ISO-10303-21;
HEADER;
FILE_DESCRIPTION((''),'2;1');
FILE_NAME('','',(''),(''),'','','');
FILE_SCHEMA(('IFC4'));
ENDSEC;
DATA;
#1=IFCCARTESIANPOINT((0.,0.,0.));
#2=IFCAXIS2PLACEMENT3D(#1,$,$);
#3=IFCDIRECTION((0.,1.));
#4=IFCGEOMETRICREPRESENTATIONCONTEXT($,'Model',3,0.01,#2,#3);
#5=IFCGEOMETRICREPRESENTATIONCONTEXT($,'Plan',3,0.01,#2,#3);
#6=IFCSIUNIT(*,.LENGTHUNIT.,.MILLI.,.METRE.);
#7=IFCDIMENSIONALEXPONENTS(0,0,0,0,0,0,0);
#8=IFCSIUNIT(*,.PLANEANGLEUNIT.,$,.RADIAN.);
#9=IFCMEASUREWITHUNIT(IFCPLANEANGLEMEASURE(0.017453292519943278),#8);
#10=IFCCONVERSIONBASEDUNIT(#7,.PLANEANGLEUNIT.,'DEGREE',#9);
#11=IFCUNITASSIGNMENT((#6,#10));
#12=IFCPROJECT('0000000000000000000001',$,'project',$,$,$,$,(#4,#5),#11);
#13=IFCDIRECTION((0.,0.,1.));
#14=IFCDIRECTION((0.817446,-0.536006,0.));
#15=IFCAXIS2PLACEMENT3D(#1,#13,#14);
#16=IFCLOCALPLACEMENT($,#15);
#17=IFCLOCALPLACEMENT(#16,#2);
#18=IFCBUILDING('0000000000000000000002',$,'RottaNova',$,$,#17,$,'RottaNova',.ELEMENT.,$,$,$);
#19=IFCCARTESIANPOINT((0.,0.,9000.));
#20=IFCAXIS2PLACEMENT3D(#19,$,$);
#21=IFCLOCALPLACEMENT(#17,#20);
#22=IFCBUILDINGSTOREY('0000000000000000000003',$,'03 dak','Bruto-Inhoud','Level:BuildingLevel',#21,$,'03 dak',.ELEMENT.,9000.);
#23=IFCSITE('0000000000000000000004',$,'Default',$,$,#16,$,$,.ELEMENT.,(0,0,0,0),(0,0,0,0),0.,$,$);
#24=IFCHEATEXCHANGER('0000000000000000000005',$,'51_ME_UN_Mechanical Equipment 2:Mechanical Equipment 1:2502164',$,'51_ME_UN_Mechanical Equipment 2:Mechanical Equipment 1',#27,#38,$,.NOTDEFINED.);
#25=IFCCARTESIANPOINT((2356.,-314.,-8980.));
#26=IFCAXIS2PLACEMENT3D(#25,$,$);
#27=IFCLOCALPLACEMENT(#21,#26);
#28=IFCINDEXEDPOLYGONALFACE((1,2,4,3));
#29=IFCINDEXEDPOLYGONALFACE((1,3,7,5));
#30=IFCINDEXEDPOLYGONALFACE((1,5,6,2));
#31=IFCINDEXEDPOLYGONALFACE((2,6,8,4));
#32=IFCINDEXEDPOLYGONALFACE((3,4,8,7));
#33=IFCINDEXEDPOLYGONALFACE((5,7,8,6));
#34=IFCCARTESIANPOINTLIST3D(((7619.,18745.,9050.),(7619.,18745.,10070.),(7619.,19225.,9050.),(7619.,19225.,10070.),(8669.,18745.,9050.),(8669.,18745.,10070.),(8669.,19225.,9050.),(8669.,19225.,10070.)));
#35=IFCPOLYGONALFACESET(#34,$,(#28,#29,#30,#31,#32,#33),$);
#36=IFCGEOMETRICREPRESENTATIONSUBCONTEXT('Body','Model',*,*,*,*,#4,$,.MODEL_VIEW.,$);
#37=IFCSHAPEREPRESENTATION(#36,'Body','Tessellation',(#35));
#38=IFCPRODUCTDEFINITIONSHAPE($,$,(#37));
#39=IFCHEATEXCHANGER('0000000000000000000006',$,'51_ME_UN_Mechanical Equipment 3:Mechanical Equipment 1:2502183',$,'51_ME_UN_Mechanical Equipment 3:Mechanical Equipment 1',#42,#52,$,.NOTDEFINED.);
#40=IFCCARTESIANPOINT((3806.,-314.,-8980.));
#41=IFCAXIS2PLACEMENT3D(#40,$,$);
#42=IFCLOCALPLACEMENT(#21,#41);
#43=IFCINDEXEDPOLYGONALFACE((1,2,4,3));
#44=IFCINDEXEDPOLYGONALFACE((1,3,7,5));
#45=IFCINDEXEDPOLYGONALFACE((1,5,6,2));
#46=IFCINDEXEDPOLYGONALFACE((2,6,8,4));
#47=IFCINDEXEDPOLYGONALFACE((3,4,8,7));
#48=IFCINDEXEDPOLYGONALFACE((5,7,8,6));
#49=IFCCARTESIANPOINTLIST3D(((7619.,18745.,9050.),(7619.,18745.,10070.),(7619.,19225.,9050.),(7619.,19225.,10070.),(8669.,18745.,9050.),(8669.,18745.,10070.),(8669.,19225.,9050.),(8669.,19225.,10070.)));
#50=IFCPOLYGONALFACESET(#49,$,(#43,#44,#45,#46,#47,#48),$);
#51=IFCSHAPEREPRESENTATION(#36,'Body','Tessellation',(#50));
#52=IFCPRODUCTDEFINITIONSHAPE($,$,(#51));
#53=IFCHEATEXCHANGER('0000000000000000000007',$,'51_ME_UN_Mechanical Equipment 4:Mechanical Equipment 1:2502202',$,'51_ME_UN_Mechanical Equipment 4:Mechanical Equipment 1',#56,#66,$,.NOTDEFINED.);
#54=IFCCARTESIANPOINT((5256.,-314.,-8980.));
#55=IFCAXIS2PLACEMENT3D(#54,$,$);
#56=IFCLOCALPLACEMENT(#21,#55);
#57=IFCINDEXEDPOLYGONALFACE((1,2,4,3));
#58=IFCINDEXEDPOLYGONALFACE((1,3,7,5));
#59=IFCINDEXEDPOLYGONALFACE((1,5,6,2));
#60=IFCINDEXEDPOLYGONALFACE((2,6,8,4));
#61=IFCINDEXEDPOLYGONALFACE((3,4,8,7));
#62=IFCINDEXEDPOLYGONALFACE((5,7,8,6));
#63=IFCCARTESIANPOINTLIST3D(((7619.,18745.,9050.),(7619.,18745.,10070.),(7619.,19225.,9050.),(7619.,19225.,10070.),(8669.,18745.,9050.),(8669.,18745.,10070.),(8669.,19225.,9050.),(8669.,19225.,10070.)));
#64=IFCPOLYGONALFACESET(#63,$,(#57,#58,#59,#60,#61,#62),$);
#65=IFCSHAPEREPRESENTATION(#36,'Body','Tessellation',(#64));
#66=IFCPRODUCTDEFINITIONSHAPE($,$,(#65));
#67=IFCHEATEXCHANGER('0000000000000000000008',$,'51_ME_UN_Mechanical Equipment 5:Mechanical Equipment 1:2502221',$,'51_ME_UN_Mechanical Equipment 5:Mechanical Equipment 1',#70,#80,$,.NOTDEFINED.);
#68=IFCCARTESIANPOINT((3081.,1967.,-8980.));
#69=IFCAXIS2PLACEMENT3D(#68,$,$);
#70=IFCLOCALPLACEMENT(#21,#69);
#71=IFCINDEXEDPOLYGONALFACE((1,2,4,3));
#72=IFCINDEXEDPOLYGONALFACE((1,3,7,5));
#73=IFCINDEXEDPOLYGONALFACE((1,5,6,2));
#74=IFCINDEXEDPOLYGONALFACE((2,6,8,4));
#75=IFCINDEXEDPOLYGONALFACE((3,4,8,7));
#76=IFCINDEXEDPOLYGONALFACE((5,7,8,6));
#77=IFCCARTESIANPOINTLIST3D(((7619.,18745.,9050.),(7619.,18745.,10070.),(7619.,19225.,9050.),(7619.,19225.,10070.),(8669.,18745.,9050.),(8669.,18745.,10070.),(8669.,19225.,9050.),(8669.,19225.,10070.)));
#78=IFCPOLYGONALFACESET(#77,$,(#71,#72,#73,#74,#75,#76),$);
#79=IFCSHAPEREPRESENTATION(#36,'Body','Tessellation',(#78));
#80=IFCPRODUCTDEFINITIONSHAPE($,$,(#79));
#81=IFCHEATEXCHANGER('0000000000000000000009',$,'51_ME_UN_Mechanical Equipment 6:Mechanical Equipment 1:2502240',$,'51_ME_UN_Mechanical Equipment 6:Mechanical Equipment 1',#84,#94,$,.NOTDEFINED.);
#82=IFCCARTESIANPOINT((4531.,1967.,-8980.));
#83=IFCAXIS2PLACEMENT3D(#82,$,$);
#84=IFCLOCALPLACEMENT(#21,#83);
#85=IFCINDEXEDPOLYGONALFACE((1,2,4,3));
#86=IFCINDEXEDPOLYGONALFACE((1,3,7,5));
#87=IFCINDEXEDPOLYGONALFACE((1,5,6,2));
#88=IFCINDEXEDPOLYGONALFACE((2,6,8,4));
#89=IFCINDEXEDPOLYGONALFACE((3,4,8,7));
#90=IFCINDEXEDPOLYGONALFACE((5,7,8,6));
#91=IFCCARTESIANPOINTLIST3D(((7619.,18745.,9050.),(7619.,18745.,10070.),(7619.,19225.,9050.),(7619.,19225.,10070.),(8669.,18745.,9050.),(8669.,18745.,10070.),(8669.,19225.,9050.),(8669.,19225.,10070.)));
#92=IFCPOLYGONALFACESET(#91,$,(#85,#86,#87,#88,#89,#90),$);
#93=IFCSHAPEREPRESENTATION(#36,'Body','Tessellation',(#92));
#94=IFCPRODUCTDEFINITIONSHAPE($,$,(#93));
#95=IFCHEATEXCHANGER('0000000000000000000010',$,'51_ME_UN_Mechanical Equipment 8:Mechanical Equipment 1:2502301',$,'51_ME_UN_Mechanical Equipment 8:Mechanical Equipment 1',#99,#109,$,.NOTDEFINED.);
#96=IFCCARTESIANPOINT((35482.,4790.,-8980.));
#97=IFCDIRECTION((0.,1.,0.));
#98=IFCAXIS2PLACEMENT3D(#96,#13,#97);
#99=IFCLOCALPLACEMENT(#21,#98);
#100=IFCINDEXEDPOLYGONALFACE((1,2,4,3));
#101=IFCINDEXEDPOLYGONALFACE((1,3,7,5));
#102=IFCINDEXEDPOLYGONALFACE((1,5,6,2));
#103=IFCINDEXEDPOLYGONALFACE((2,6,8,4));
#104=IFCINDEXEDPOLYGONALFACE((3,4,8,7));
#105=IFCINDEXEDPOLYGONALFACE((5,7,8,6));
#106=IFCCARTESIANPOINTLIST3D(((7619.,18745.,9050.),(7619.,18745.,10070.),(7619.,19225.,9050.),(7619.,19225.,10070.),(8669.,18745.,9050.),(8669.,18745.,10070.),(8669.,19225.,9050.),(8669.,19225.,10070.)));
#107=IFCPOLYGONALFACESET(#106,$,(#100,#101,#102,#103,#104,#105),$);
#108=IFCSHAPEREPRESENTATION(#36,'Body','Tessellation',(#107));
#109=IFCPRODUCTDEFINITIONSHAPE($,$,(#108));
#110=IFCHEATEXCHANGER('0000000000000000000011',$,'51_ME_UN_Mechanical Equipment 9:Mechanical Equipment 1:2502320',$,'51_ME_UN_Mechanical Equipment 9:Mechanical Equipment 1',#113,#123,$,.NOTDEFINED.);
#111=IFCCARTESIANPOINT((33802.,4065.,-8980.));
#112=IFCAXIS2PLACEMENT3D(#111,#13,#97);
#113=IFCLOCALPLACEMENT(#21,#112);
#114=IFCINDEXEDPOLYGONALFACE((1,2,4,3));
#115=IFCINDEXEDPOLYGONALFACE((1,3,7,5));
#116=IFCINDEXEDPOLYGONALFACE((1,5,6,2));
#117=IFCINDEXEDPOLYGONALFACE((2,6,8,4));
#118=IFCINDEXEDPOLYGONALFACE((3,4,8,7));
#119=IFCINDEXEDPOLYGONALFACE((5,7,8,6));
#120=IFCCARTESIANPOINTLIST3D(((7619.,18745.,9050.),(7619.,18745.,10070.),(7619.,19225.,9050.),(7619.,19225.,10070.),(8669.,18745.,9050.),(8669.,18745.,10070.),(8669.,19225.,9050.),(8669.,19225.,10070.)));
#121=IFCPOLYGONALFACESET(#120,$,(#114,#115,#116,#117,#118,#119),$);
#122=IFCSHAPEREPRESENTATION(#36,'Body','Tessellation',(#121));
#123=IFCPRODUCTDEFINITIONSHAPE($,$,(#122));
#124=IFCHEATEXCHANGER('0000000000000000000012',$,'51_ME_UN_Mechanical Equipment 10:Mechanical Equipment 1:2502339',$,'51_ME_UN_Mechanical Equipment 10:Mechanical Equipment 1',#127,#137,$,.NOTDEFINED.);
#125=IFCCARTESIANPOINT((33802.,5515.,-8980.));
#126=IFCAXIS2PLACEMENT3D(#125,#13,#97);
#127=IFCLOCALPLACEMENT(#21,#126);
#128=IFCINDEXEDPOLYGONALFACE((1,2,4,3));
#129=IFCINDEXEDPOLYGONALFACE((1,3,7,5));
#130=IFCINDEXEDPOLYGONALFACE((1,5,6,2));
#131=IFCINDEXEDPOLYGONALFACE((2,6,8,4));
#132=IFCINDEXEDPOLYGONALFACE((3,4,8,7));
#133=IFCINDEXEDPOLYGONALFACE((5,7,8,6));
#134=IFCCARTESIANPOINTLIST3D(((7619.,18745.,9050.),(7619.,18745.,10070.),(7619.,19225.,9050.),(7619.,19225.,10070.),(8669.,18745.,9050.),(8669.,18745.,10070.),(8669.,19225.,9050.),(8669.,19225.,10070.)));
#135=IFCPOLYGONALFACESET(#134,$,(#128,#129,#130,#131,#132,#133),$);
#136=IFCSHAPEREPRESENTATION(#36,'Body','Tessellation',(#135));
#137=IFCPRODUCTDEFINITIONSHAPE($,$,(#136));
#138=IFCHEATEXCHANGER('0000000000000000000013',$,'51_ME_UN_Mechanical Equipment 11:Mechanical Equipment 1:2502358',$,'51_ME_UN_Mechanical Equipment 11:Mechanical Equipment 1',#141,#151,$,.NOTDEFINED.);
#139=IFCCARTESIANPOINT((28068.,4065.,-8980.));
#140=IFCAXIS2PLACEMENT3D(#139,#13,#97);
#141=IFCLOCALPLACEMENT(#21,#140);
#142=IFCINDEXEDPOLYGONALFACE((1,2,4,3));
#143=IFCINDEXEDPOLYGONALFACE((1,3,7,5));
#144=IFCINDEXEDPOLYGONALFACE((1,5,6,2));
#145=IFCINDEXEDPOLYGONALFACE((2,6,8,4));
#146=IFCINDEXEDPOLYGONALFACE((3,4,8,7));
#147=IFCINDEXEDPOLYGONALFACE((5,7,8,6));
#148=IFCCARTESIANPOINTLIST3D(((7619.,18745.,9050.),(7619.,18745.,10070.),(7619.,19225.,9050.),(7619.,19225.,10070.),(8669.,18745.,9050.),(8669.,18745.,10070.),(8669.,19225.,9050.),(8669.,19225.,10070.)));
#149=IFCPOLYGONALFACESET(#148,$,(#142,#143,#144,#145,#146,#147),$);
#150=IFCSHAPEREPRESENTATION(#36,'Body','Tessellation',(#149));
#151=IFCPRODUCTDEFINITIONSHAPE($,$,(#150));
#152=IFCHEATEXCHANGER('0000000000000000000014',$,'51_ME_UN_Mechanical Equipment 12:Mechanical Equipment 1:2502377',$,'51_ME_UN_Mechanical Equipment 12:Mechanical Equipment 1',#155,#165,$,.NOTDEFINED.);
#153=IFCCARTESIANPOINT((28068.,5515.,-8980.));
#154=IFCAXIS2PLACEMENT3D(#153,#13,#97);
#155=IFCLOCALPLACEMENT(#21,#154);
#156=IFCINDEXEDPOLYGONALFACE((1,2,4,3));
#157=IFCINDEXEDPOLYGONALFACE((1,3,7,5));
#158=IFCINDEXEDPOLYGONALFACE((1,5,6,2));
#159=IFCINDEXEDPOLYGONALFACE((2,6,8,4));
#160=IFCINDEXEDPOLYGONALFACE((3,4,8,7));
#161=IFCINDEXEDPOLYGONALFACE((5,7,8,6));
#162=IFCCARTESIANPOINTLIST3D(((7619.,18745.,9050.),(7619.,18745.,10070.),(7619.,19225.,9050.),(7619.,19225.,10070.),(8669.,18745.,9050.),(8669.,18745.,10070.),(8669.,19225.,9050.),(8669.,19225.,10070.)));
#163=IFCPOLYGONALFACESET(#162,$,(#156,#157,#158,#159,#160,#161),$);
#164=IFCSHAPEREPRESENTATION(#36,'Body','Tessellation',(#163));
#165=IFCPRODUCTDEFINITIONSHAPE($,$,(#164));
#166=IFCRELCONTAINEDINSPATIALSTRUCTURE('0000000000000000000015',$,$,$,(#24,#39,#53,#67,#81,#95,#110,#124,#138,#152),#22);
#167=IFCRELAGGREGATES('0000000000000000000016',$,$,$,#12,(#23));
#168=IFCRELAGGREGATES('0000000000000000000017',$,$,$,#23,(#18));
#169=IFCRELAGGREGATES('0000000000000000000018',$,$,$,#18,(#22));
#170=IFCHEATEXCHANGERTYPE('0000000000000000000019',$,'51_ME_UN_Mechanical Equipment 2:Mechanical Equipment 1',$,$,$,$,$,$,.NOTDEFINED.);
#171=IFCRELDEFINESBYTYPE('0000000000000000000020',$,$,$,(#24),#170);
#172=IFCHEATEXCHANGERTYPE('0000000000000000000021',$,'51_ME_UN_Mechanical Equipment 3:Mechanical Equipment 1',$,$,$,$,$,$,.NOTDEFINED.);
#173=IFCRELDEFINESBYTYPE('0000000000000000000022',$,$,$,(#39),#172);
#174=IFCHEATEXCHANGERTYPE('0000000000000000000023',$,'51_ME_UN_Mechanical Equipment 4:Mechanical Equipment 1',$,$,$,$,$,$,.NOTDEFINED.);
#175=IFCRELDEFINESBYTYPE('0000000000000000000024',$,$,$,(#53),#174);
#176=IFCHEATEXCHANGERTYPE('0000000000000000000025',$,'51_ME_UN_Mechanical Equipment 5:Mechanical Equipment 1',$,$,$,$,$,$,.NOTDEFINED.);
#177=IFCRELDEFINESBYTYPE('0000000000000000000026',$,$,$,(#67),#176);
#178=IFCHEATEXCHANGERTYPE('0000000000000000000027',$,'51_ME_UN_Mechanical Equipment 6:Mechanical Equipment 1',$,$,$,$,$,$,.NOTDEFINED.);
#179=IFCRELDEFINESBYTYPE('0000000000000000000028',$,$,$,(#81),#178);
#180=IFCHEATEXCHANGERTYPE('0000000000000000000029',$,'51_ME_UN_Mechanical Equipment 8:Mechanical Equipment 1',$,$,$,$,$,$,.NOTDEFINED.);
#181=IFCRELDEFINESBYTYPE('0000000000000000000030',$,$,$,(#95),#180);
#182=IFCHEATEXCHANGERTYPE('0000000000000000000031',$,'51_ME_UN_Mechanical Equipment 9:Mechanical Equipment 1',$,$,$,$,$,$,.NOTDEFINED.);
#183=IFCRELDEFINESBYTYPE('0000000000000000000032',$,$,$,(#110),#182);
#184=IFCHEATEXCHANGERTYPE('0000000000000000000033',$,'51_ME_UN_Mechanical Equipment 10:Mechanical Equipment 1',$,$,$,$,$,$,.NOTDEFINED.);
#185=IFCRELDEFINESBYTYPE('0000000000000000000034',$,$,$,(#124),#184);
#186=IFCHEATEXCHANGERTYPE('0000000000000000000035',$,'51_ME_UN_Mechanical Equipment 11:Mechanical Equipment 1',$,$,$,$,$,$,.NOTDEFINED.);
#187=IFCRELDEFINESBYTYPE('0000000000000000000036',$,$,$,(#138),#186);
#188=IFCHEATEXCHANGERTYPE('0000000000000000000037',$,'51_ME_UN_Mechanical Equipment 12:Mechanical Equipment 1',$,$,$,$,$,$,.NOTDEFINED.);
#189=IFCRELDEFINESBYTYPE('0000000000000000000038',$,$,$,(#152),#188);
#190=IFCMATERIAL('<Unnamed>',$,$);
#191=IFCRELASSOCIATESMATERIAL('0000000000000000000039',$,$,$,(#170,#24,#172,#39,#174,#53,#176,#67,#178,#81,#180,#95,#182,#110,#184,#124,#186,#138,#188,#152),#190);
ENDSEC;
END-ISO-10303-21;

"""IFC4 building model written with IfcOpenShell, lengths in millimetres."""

from ifc_helpers import new_model, entity, si_unit, converted_unit, direction, frame, origin, place, context, subcontext, project, spatial, indexed_curve, outline, extrude, source, transform, mapped, material, type_object, type_shapes, element, save


model = new_model("IFC4")

# Units and contexts
model_context = context("Model", 3, precision=0.01, world=origin(), true_north=direction((0.0, 1.0)))
plan_context = context("Plan", 3, precision=0.01, world=origin(), true_north=direction((0.0, 1.0)))
body_context = subcontext(model_context, "Body", "Model", "MODEL_VIEW")
ifc_project = project(units=[si_unit("LENGTHUNIT", "METRE", prefix="MILLI"), converted_unit("PLANEANGLEUNIT", "DEGREE", entity("IfcPlaneAngleMeasure", 0.017453292519943278), si_unit("PLANEANGLEUNIT", "RADIAN"), dimensions=[0, 0, 0, 0, 0, 0, 0])], contexts=[model_context, plan_context])

# Site, building, storey
site_placement = place(None, frame((0.0, 0.0, 0.0), z_axis=(0.0, 0.0, 1.0), x_axis=(0.817446, -0.536006, 0.0)))
site = spatial("IfcSite", under=ifc_project, at=site_placement, Name="Default", CompositionType="ELEMENT", RefLatitude=(0, 0, 0, 0), RefLongitude=(0, 0, 0, 0), RefElevation=0.0)
building_placement = place(site_placement, origin())
building = spatial("IfcBuilding", under=site, at=building_placement, Name="RottaNova", LongName="RottaNova", CompositionType="ELEMENT")
storey_placement = place(building_placement, frame((0.0, 0.0, 9000.0)))
storey = spatial("IfcBuildingStorey", under=building, at=storey_placement, Name="03 dak", Description="Bruto-Inhoud", ObjectType="Level:BuildingLevel", LongName="03 dak", CompositionType="ELEMENT", Elevation=9000.0)

# Heat exchangers
ifc_material_1 = material(Name="<Unnamed>")
heat_exchanger_type_1 = type_object("IfcHeatExchangerType", Name="51_ME_UN_Mechanical Equipment 2:Mechanical Equipment 1", PredefinedType="NOTDEFINED", material=ifc_material_1)
shared_shape_1 = source(origin(), body_context, "Body", "SweptSolid", [
    extrude(outline(indexed_curve([(-525.0, -240.0), (525.0, -240.0), (525.0, 240.0), (-525.0, 240.0), (-525.0, -240.0)], self_intersect=False)), frame((8144.0, 18985.0, 9050.0), z_axis=(0.0, 0.0, 1.0), x_axis=(-1.0, 0.0, 0.0)), (0.0, 0.0, 1.0), 1020.0),
])
type_shapes(heat_exchanger_type_1, [shared_shape_1])
heat_exchanger_1_placement = place(storey_placement, frame((2356.0, -314.0, -8980.0)))
element("IfcHeatExchanger", 1, at=heat_exchanger_1_placement, inside=storey, type_object=heat_exchanger_type_1, material=ifc_material_1, Name="51_ME_UN_Mechanical Equipment 2:Mechanical Equipment 1:2502164", ObjectType="51_ME_UN_Mechanical Equipment 2:Mechanical Equipment 1", PredefinedType="NOTDEFINED", context=body_context, shape_type="MappedRepresentation", body=[
    mapped(shared_shape_1, transform((0.0, 0.0, 0.0), scale=1.0)),
])
heat_exchanger_type_2 = type_object("IfcHeatExchangerType", Name="51_ME_UN_Mechanical Equipment 3:Mechanical Equipment 1", PredefinedType="NOTDEFINED", material=ifc_material_1)
shared_shape_2 = source(origin(), body_context, "Body", "SweptSolid", [
    extrude(outline(indexed_curve([(-525.0, -240.0), (525.0, -240.0), (525.0, 240.0), (-525.0, 240.0), (-525.0, -240.0)], self_intersect=False)), frame((8144.0, 18985.0, 9050.0), z_axis=(0.0, 0.0, 1.0), x_axis=(-1.0, 0.0, 0.0)), (0.0, 0.0, 1.0), 1020.0),
])
type_shapes(heat_exchanger_type_2, [shared_shape_2])
heat_exchanger_2_placement = place(storey_placement, frame((3806.0, -314.0, -8980.0)))
element("IfcHeatExchanger", 2, at=heat_exchanger_2_placement, inside=storey, type_object=heat_exchanger_type_2, material=ifc_material_1, Name="51_ME_UN_Mechanical Equipment 3:Mechanical Equipment 1:2502183", ObjectType="51_ME_UN_Mechanical Equipment 3:Mechanical Equipment 1", PredefinedType="NOTDEFINED", context=body_context, shape_type="MappedRepresentation", body=[
    mapped(shared_shape_2, transform((0.0, 0.0, 0.0), scale=1.0)),
])
heat_exchanger_type_3 = type_object("IfcHeatExchangerType", Name="51_ME_UN_Mechanical Equipment 4:Mechanical Equipment 1", PredefinedType="NOTDEFINED", material=ifc_material_1)
shared_shape_3 = source(origin(), body_context, "Body", "SweptSolid", [
    extrude(outline(indexed_curve([(-525.0, -240.0), (525.0, -240.0), (525.0, 240.0), (-525.0, 240.0), (-525.0, -240.0)], self_intersect=False)), frame((8144.0, 18985.0, 9050.0), z_axis=(0.0, 0.0, 1.0), x_axis=(-1.0, 0.0, 0.0)), (0.0, 0.0, 1.0), 1020.0),
])
type_shapes(heat_exchanger_type_3, [shared_shape_3])
heat_exchanger_3_placement = place(storey_placement, frame((5256.0, -314.0, -8980.0)))
element("IfcHeatExchanger", 3, at=heat_exchanger_3_placement, inside=storey, type_object=heat_exchanger_type_3, material=ifc_material_1, Name="51_ME_UN_Mechanical Equipment 4:Mechanical Equipment 1:2502202", ObjectType="51_ME_UN_Mechanical Equipment 4:Mechanical Equipment 1", PredefinedType="NOTDEFINED", context=body_context, shape_type="MappedRepresentation", body=[
    mapped(shared_shape_3, transform((0.0, 0.0, 0.0), scale=1.0)),
])
heat_exchanger_type_4 = type_object("IfcHeatExchangerType", Name="51_ME_UN_Mechanical Equipment 5:Mechanical Equipment 1", PredefinedType="NOTDEFINED", material=ifc_material_1)
shared_shape_4 = source(origin(), body_context, "Body", "SweptSolid", [
    extrude(outline(indexed_curve([(-525.0, -240.0), (525.0, -240.0), (525.0, 240.0), (-525.0, 240.0), (-525.0, -240.0)], self_intersect=False)), frame((8144.0, 18985.0, 9050.0), z_axis=(0.0, 0.0, 1.0), x_axis=(-1.0, 0.0, 0.0)), (0.0, 0.0, 1.0), 1020.0),
])
type_shapes(heat_exchanger_type_4, [shared_shape_4])
heat_exchanger_4_placement = place(storey_placement, frame((3081.0, 1967.0, -8980.0)))
element("IfcHeatExchanger", 4, at=heat_exchanger_4_placement, inside=storey, type_object=heat_exchanger_type_4, material=ifc_material_1, Name="51_ME_UN_Mechanical Equipment 5:Mechanical Equipment 1:2502221", ObjectType="51_ME_UN_Mechanical Equipment 5:Mechanical Equipment 1", PredefinedType="NOTDEFINED", context=body_context, shape_type="MappedRepresentation", body=[
    mapped(shared_shape_4, transform((0.0, 0.0, 0.0), scale=1.0)),
])
heat_exchanger_type_5 = type_object("IfcHeatExchangerType", Name="51_ME_UN_Mechanical Equipment 6:Mechanical Equipment 1", PredefinedType="NOTDEFINED", material=ifc_material_1)
shared_shape_5 = source(origin(), body_context, "Body", "SweptSolid", [
    extrude(outline(indexed_curve([(-525.0, -240.0), (525.0, -240.0), (525.0, 240.0), (-525.0, 240.0), (-525.0, -240.0)], self_intersect=False)), frame((8144.0, 18985.0, 9050.0), z_axis=(0.0, 0.0, 1.0), x_axis=(-1.0, 0.0, 0.0)), (0.0, 0.0, 1.0), 1020.0),
])
type_shapes(heat_exchanger_type_5, [shared_shape_5])
heat_exchanger_5_placement = place(storey_placement, frame((4531.0, 1967.0, -8980.0)))
element("IfcHeatExchanger", 5, at=heat_exchanger_5_placement, inside=storey, type_object=heat_exchanger_type_5, material=ifc_material_1, Name="51_ME_UN_Mechanical Equipment 6:Mechanical Equipment 1:2502240", ObjectType="51_ME_UN_Mechanical Equipment 6:Mechanical Equipment 1", PredefinedType="NOTDEFINED", context=body_context, shape_type="MappedRepresentation", body=[
    mapped(shared_shape_5, transform((0.0, 0.0, 0.0), scale=1.0)),
])
heat_exchanger_type_6 = type_object("IfcHeatExchangerType", Name="51_ME_UN_Mechanical Equipment 8:Mechanical Equipment 1", PredefinedType="NOTDEFINED", material=ifc_material_1)
shared_shape_6 = source(origin(), body_context, "Body", "SweptSolid", [
    extrude(outline(indexed_curve([(-525.0, -240.0), (525.0, -240.0), (525.0, 240.0), (-525.0, 240.0), (-525.0, -240.0)], self_intersect=False)), frame((8144.0, 18985.0, 9050.0), z_axis=(0.0, 0.0, 1.0), x_axis=(-1.0, 0.0, 0.0)), (0.0, 0.0, 1.0), 1020.0),
])
type_shapes(heat_exchanger_type_6, [shared_shape_6])
heat_exchanger_6_placement = place(storey_placement, frame((35482.0, 4790.0, -8980.0), z_axis=(0.0, 0.0, 1.0), x_axis=(0.0, 1.0, 0.0)))
element("IfcHeatExchanger", 6, at=heat_exchanger_6_placement, inside=storey, type_object=heat_exchanger_type_6, material=ifc_material_1, Name="51_ME_UN_Mechanical Equipment 8:Mechanical Equipment 1:2502301", ObjectType="51_ME_UN_Mechanical Equipment 8:Mechanical Equipment 1", PredefinedType="NOTDEFINED", context=body_context, shape_type="MappedRepresentation", body=[
    mapped(shared_shape_6, transform((0.0, 0.0, 0.0), scale=1.0)),
])
heat_exchanger_type_7 = type_object("IfcHeatExchangerType", Name="51_ME_UN_Mechanical Equipment 9:Mechanical Equipment 1", PredefinedType="NOTDEFINED", material=ifc_material_1)
shared_shape_7 = source(origin(), body_context, "Body", "SweptSolid", [
    extrude(outline(indexed_curve([(-525.0, -240.0), (525.0, -240.0), (525.0, 240.0), (-525.0, 240.0), (-525.0, -240.0)], self_intersect=False)), frame((8144.0, 18985.0, 9050.0), z_axis=(0.0, 0.0, 1.0), x_axis=(-1.0, 0.0, 0.0)), (0.0, 0.0, 1.0), 1020.0),
])
type_shapes(heat_exchanger_type_7, [shared_shape_7])
heat_exchanger_7_placement = place(storey_placement, frame((33802.0, 4065.0, -8980.0), z_axis=(0.0, 0.0, 1.0), x_axis=(0.0, 1.0, 0.0)))
element("IfcHeatExchanger", 7, at=heat_exchanger_7_placement, inside=storey, type_object=heat_exchanger_type_7, material=ifc_material_1, Name="51_ME_UN_Mechanical Equipment 9:Mechanical Equipment 1:2502320", ObjectType="51_ME_UN_Mechanical Equipment 9:Mechanical Equipment 1", PredefinedType="NOTDEFINED", context=body_context, shape_type="MappedRepresentation", body=[
    mapped(shared_shape_7, transform((0.0, 0.0, 0.0), scale=1.0)),
])
heat_exchanger_type_8 = type_object("IfcHeatExchangerType", Name="51_ME_UN_Mechanical Equipment 10:Mechanical Equipment 1", PredefinedType="NOTDEFINED", material=ifc_material_1)
shared_shape_8 = source(origin(), body_context, "Body", "SweptSolid", [
    extrude(outline(indexed_curve([(-525.0, -240.0), (525.0, -240.0), (525.0, 240.0), (-525.0, 240.0), (-525.0, -240.0)], self_intersect=False)), frame((8144.0, 18985.0, 9050.0), z_axis=(0.0, 0.0, 1.0), x_axis=(-1.0, 0.0, 0.0)), (0.0, 0.0, 1.0), 1020.0),
])
type_shapes(heat_exchanger_type_8, [shared_shape_8])
heat_exchanger_8_placement = place(storey_placement, frame((33802.0, 5515.0, -8980.0), z_axis=(0.0, 0.0, 1.0), x_axis=(0.0, 1.0, 0.0)))
element("IfcHeatExchanger", 8, at=heat_exchanger_8_placement, inside=storey, type_object=heat_exchanger_type_8, material=ifc_material_1, Name="51_ME_UN_Mechanical Equipment 10:Mechanical Equipment 1:2502339", ObjectType="51_ME_UN_Mechanical Equipment 10:Mechanical Equipment 1", PredefinedType="NOTDEFINED", context=body_context, shape_type="MappedRepresentation", body=[
    mapped(shared_shape_8, transform((0.0, 0.0, 0.0), scale=1.0)),
])
heat_exchanger_type_9 = type_object("IfcHeatExchangerType", Name="51_ME_UN_Mechanical Equipment 11:Mechanical Equipment 1", PredefinedType="NOTDEFINED", material=ifc_material_1)
shared_shape_9 = source(origin(), body_context, "Body", "SweptSolid", [
    extrude(outline(indexed_curve([(-525.0, -240.0), (525.0, -240.0), (525.0, 240.0), (-525.0, 240.0), (-525.0, -240.0)], self_intersect=False)), frame((8144.0, 18985.0, 9050.0), z_axis=(0.0, 0.0, 1.0), x_axis=(-1.0, 0.0, 0.0)), (0.0, 0.0, 1.0), 1020.0),
])
type_shapes(heat_exchanger_type_9, [shared_shape_9])
heat_exchanger_9_placement = place(storey_placement, frame((28068.0, 4065.0, -8980.0), z_axis=(0.0, 0.0, 1.0), x_axis=(0.0, 1.0, 0.0)))
element("IfcHeatExchanger", 9, at=heat_exchanger_9_placement, inside=storey, type_object=heat_exchanger_type_9, material=ifc_material_1, Name="51_ME_UN_Mechanical Equipment 11:Mechanical Equipment 1:2502358", ObjectType="51_ME_UN_Mechanical Equipment 11:Mechanical Equipment 1", PredefinedType="NOTDEFINED", context=body_context, shape_type="MappedRepresentation", body=[
    mapped(shared_shape_9, transform((0.0, 0.0, 0.0), scale=1.0)),
])
heat_exchanger_type_10 = type_object("IfcHeatExchangerType", Name="51_ME_UN_Mechanical Equipment 12:Mechanical Equipment 1", PredefinedType="NOTDEFINED", material=ifc_material_1)
shared_shape_10 = source(origin(), body_context, "Body", "SweptSolid", [
    extrude(outline(indexed_curve([(-525.0, -240.0), (525.0, -240.0), (525.0, 240.0), (-525.0, 240.0), (-525.0, -240.0)], self_intersect=False)), frame((8144.0, 18985.0, 9050.0), z_axis=(0.0, 0.0, 1.0), x_axis=(-1.0, 0.0, 0.0)), (0.0, 0.0, 1.0), 1020.0),
])
type_shapes(heat_exchanger_type_10, [shared_shape_10])
heat_exchanger_10_placement = place(storey_placement, frame((28068.0, 5515.0, -8980.0), z_axis=(0.0, 0.0, 1.0), x_axis=(0.0, 1.0, 0.0)))
element("IfcHeatExchanger", 10, at=heat_exchanger_10_placement, inside=storey, type_object=heat_exchanger_type_10, material=ifc_material_1, Name="51_ME_UN_Mechanical Equipment 12:Mechanical Equipment 1:2502377", ObjectType="51_ME_UN_Mechanical Equipment 12:Mechanical Equipment 1", PredefinedType="NOTDEFINED", context=body_context, shape_type="MappedRepresentation", body=[
    mapped(shared_shape_10, transform((0.0, 0.0, 0.0), scale=1.0)),
])

save(model, "model.ifc")
